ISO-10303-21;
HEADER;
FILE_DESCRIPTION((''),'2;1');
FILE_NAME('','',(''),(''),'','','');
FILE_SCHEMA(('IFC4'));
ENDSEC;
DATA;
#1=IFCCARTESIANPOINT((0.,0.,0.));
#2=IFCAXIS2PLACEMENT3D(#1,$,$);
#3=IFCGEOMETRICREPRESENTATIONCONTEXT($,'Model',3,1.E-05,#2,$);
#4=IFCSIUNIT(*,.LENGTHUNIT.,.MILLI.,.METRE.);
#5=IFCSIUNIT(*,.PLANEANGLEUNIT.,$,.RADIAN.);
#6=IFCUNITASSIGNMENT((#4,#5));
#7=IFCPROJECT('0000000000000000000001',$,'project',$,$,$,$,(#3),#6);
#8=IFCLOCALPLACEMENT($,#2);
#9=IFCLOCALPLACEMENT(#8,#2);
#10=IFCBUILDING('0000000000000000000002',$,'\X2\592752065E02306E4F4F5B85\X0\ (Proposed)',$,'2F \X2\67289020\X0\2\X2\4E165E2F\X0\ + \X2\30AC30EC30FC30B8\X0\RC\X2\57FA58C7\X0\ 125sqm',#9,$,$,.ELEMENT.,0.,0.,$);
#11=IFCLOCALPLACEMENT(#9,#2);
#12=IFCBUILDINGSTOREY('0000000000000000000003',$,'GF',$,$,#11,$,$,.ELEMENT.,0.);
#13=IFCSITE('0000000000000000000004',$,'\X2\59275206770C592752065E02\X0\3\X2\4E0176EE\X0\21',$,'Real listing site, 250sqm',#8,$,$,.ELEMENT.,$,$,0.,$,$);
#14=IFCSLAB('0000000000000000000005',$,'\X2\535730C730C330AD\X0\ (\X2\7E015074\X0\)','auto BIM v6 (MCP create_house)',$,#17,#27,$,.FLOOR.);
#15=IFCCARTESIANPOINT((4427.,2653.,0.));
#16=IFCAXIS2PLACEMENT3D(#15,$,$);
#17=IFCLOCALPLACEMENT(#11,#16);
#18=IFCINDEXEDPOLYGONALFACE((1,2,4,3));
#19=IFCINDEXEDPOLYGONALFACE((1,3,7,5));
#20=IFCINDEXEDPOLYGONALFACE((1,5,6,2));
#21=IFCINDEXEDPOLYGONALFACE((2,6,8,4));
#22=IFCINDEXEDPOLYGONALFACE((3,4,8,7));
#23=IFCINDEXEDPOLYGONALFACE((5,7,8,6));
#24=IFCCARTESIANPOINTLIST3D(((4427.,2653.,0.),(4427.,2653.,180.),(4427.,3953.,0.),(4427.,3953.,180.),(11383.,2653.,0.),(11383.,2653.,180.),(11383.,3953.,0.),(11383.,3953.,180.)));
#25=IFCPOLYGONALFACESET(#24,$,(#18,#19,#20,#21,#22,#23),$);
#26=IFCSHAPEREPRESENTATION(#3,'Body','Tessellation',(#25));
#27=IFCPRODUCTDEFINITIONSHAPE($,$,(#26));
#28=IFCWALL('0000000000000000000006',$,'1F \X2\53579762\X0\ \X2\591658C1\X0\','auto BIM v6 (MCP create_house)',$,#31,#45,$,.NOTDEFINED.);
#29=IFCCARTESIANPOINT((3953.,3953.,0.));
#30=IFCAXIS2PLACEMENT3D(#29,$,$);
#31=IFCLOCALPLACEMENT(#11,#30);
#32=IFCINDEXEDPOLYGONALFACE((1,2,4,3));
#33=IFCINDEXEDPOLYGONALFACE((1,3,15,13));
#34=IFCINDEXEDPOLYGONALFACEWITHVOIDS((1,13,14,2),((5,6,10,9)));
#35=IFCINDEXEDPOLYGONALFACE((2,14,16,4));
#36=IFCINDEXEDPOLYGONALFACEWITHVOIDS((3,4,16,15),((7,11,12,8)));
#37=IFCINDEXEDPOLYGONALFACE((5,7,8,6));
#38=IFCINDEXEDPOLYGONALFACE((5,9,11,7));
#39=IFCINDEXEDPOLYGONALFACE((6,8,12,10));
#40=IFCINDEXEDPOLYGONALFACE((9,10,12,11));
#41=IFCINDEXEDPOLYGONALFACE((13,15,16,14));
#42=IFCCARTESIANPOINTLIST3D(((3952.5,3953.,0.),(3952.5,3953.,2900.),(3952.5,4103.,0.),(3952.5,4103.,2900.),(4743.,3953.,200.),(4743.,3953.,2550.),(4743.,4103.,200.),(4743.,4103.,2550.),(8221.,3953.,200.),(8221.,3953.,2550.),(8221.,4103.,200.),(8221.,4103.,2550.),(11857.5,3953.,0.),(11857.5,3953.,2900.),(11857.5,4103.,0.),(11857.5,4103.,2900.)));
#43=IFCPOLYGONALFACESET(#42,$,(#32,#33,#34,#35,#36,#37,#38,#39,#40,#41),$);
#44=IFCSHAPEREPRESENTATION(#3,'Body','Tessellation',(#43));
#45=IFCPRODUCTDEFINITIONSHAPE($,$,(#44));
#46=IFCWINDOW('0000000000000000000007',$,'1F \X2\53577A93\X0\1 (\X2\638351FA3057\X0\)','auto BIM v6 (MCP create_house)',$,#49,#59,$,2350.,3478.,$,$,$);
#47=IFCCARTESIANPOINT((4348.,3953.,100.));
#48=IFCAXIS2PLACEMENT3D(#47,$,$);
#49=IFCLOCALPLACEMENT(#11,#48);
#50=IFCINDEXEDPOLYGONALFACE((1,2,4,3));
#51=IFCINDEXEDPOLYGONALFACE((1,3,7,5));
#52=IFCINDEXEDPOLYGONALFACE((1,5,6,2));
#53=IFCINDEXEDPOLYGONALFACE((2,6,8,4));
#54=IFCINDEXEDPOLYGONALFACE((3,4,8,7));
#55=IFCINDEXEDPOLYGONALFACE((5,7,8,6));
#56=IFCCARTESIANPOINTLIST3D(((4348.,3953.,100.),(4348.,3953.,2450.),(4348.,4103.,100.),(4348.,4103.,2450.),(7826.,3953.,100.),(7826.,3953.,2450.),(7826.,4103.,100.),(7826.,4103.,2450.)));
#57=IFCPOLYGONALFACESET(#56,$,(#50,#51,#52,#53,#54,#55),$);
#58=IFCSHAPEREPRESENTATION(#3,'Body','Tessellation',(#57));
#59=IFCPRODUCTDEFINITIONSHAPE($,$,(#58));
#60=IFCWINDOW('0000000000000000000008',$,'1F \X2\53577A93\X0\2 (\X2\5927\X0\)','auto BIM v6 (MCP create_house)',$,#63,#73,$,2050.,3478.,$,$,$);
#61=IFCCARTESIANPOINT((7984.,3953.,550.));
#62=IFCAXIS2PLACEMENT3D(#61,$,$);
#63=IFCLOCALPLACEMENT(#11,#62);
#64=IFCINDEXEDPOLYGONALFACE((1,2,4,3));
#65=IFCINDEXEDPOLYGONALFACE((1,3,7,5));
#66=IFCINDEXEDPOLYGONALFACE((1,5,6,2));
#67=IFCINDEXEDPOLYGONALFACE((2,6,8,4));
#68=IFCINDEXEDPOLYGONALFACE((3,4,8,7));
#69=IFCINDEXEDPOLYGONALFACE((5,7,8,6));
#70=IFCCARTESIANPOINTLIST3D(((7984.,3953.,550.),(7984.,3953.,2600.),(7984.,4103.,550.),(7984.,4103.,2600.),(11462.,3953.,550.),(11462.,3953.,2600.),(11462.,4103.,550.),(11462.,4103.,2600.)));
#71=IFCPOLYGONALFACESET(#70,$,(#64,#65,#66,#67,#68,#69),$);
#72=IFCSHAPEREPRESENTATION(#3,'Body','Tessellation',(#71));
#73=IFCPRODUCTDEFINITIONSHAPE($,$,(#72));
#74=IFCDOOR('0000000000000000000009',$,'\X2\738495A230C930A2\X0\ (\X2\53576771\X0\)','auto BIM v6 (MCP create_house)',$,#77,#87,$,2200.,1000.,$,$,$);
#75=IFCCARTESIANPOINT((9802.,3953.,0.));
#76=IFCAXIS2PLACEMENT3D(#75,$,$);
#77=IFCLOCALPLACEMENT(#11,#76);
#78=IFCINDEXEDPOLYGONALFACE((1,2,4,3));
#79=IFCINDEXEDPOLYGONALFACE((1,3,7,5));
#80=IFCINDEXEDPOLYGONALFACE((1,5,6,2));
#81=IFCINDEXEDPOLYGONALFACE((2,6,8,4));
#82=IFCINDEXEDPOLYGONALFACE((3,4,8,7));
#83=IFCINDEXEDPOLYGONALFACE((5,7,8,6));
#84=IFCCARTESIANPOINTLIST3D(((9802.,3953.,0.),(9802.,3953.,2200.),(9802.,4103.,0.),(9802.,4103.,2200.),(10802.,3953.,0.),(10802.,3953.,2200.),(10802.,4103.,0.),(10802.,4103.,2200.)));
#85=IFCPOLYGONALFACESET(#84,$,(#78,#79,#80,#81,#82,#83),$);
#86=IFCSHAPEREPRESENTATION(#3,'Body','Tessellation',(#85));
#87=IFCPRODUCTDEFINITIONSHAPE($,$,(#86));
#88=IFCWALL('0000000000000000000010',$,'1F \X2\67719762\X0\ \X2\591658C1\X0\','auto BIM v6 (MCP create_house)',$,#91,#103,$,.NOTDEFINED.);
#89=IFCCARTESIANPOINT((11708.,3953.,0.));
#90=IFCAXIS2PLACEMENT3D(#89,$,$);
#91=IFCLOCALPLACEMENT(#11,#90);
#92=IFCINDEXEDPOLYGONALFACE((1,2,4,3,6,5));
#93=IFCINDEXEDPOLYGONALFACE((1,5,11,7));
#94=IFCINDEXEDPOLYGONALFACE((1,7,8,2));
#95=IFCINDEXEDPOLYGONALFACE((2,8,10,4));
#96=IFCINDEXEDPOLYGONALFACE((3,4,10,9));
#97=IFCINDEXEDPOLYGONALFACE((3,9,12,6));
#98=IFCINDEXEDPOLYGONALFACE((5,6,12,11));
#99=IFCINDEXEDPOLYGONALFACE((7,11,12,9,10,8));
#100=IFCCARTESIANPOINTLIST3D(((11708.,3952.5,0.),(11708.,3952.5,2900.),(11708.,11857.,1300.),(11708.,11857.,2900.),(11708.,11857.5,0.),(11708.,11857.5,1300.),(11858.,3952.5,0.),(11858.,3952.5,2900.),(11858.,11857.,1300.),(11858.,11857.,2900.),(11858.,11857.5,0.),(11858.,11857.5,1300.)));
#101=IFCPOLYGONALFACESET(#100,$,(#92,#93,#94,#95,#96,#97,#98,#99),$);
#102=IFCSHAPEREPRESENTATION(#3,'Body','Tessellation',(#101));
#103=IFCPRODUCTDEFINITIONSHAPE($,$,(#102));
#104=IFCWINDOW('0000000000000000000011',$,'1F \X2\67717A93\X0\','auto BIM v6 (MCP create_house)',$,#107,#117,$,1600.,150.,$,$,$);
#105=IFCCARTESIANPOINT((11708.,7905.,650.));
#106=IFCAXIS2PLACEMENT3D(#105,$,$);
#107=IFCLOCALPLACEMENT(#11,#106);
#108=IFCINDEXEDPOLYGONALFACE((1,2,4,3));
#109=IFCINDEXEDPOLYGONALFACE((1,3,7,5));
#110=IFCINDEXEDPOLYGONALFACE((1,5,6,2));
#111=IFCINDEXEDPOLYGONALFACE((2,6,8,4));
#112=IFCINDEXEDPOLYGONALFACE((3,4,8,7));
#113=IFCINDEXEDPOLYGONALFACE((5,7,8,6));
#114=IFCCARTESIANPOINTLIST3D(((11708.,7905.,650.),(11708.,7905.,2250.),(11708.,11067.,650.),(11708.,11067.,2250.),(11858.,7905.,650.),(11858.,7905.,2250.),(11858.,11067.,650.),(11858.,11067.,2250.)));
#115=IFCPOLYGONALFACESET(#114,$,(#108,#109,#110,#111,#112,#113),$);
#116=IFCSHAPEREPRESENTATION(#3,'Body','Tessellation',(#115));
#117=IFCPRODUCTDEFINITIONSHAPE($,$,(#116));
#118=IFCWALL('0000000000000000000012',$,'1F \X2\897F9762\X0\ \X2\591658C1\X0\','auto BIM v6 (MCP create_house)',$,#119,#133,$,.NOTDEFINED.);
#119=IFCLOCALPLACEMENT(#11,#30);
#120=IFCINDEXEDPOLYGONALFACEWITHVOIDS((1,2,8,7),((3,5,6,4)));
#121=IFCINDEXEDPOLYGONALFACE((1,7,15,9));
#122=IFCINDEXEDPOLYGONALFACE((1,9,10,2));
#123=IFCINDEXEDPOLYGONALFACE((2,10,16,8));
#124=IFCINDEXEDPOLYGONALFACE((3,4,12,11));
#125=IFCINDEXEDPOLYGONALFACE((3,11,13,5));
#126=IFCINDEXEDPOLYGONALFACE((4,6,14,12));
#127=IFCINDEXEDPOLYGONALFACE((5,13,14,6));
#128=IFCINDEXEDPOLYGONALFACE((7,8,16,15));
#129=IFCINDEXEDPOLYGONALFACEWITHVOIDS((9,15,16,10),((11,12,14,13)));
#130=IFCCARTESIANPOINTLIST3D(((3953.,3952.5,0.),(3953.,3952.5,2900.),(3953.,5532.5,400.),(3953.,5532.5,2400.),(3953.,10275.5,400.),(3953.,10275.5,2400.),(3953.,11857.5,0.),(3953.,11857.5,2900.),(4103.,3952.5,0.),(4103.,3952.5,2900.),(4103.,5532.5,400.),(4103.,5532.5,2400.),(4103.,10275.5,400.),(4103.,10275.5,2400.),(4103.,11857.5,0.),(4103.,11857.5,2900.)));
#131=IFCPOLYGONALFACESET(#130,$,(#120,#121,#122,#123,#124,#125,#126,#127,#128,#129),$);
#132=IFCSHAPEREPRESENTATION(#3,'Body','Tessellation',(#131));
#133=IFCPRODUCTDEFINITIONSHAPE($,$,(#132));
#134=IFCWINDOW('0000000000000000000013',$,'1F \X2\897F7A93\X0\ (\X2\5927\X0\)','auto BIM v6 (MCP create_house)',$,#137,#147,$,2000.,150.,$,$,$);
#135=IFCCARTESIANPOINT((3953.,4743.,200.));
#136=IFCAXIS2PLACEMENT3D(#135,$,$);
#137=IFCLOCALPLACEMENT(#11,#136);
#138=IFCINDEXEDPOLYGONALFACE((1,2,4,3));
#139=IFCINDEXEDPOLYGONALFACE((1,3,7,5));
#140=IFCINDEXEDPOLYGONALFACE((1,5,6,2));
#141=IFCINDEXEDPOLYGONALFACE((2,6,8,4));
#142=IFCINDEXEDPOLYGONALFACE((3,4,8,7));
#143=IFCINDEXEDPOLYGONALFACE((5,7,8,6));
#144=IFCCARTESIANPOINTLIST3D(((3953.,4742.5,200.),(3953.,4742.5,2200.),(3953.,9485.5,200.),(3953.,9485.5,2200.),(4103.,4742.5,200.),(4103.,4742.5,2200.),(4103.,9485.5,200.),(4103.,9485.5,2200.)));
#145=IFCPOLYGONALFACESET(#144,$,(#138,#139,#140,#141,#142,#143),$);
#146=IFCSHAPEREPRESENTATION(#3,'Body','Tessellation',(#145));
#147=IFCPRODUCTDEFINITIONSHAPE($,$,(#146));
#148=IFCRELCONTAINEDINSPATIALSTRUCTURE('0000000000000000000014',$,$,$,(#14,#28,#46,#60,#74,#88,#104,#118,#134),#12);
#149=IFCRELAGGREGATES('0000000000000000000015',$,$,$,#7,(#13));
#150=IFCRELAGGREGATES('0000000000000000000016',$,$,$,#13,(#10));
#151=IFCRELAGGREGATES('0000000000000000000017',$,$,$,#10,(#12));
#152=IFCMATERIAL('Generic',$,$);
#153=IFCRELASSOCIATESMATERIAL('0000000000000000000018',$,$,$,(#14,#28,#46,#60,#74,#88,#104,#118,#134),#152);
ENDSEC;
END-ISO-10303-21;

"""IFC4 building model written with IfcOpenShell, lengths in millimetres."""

from ifc_helpers import new_model, si_unit, frame, frame_2d, origin, place, context, project, spatial, rectangle, extrude, material, element, fill, save


model = new_model("IFC4")

# Units and contexts
model_context = context("Model", 3, precision=1e-05, world=origin())
ifc_project = project(units=[si_unit("LENGTHUNIT", "METRE", prefix="MILLI"), si_unit("PLANEANGLEUNIT", "RADIAN")], contexts=[model_context])

# Site, building, storey
site_placement = place(None, origin())
site = spatial("IfcSite", under=ifc_project, at=site_placement, Name="大分県大分市3丁目21", ObjectType="Real listing site, 250sqm", CompositionType="ELEMENT", RefElevation=0.0)
building_placement = place(site_placement, origin())
building = spatial("IfcBuilding", under=site, at=building_placement, Name="大分市の住宅 (Proposed)", ObjectType="2F 木造2世帯 + ガレージRC基壇 125sqm", CompositionType="ELEMENT", ElevationOfRefHeight=0.0, ElevationOfTerrain=0.0)
storey_placement = place(building_placement, origin())
storey = spatial("IfcBuildingStorey", under=building, at=storey_placement, Name="GF", CompositionType="ELEMENT", Elevation=0.0)

# Slab
ifc_material = material(Name="Generic")
slab_1_placement = place(storey_placement, frame((4427.0, 2653.0, 0.0)))
element("IfcSlab", 1, at=slab_1_placement, inside=storey, material=ifc_material, Name="南デッキ (縁側)", Description="auto BIM v6 (MCP create_house)", PredefinedType="FLOOR", context=model_context, shape_type="SweptSolid", body=[
    extrude(rectangle(XDim=6956.0, YDim=1300.0, at=frame_2d((3478.0, 650.0))), frame((4427.0, 2653.0, 0.0)), (0.0, 0.0, 1.0), 180.0),
])

# Wall, openings, windows, door
wall_1_placement = place(storey_placement, frame((3953.0, 3953.0, 0.0)))
wall_1 = element("IfcWall", 2, at=wall_1_placement, inside=storey, material=ifc_material, Name="1F 南面 外壁", Description="auto BIM v6 (MCP create_house)", PredefinedType="NOTDEFINED", context=model_context, shape_type="SweptSolid", body=[
    extrude(rectangle(XDim=7905.0, YDim=150.0, at=frame_2d((3952.0, 75.0))), frame((3953.0, 3953.0, 0.0)), (0.0, 0.0, 1.0), 2900.0),
])
opening_1_placement = place(storey_placement, frame((4348.0, 3953.0, 100.0)))
opening_1 = element("IfcOpeningElement", 3, at=opening_1_placement, cuts=wall_1, PredefinedType="NOTDEFINED", context=model_context, shape_type="SweptSolid", body=[
    extrude(rectangle(XDim=3478.0, YDim=150.0, at=frame_2d((1739.0, 75.0))), frame((4348.0, 3953.0, 100.0)), (0.0, 0.0, 1.0), 2350.0),
])
opening_2_placement = place(storey_placement, frame((7984.0, 3953.0, 550.0)))
opening_2 = element("IfcOpeningElement", 4, at=opening_2_placement, cuts=wall_1, PredefinedType="NOTDEFINED", context=model_context, shape_type="SweptSolid", body=[
    extrude(rectangle(XDim=3478.0, YDim=150.0, at=frame_2d((1739.0, 75.0))), frame((7984.0, 3953.0, 550.0)), (0.0, 0.0, 1.0), 2050.0),
])
opening_3_placement = place(storey_placement, frame((9802.0, 3953.0, 0.0)))
opening_3 = element("IfcOpeningElement", 5, at=opening_3_placement, cuts=wall_1, PredefinedType="NOTDEFINED", context=model_context, shape_type="SweptSolid", body=[
    extrude(rectangle(XDim=1000.0, YDim=150.0, at=frame_2d((500.0, 75.0))), frame((9802.0, 3953.0, 0.0)), (0.0, 0.0, 1.0), 2200.0),
])
window_1_placement = place(storey_placement, frame((4348.0, 3953.0, 100.0)))
window_1 = element("IfcWindow", 6, at=window_1_placement, inside=storey, material=ifc_material, Name="1F 南窓1 (掃出し)", Description="auto BIM v6 (MCP create_house)", OverallHeight=2350.0, OverallWidth=3478.0, context=model_context, shape_type="SweptSolid", body=[
    extrude(rectangle(XDim=3478.0, YDim=150.0, at=frame_2d((1739.0, 75.0))), frame((4348.0, 3953.0, 100.0)), (0.0, 0.0, 1.0), 2350.0),
])
fill(opening_1, window_1)
window_2_placement = place(storey_placement, frame((7984.0, 3953.0, 550.0)))
window_2 = element("IfcWindow", 7, at=window_2_placement, inside=storey, material=ifc_material, Name="1F 南窓2 (大)", Description="auto BIM v6 (MCP create_house)", OverallHeight=2050.0, OverallWidth=3478.0, context=model_context, shape_type="SweptSolid", body=[
    extrude(rectangle(XDim=3478.0, YDim=150.0, at=frame_2d((1739.0, 75.0))), frame((7984.0, 3953.0, 550.0)), (0.0, 0.0, 1.0), 2050.0),
])
fill(opening_2, window_2)
door_placement = place(storey_placement, frame((9802.0, 3953.0, 0.0)))
door = element("IfcDoor", 8, at=door_placement, inside=storey, material=ifc_material, Name="玄関ドア (南東)", Description="auto BIM v6 (MCP create_house)", OverallHeight=2200.0, OverallWidth=1000.0, context=model_context, shape_type="SweptSolid", body=[
    extrude(rectangle(XDim=1000.0, YDim=150.0, at=frame_2d((500.0, 75.0))), frame((9802.0, 3953.0, 0.0)), (0.0, 0.0, 1.0), 2200.0),
])
fill(opening_3, door)

# Walls, openings, windows
wall_2_placement = place(storey_placement, frame((11708.0, 3953.0, 0.0)))
wall_2 = element("IfcWall", 9, at=wall_2_placement, inside=storey, material=ifc_material, Name="1F 東面 外壁", Description="auto BIM v6 (MCP create_house)", PredefinedType="NOTDEFINED", context=model_context, shape_type="SweptSolid", body=[
    extrude(rectangle(XDim=150.0, YDim=7905.0, at=frame_2d((75.0, 3952.0))), frame((11708.0, 3953.0, 0.0)), (0.0, 0.0, 1.0), 2900.0),
])
opening_4_placement = place(storey_placement, frame((11708.0, 7905.0, 650.0)))
opening_4 = element("IfcOpeningElement", 10, at=opening_4_placement, cuts=wall_2, PredefinedType="NOTDEFINED", context=model_context, shape_type="SweptSolid", body=[
    extrude(rectangle(XDim=150.0, YDim=3162.0, at=frame_2d((75.0, 1581.0))), frame((11708.0, 7905.0, 650.0)), (0.0, 0.0, 1.0), 1600.0),
])
window_3_placement = place(storey_placement, frame((11708.0, 7905.0, 650.0)))
window_3 = element("IfcWindow", 11, at=window_3_placement, inside=storey, material=ifc_material, Name="1F 東窓", Description="auto BIM v6 (MCP create_house)", OverallHeight=1600.0, OverallWidth=150.0, context=model_context, shape_type="SweptSolid", body=[
    extrude(rectangle(XDim=150.0, YDim=3162.0, at=frame_2d((75.0, 1581.0))), frame((11708.0, 7905.0, 650.0)), (0.0, 0.0, 1.0), 1600.0),
])
fill(opening_4, window_3)
wall_3_placement = place(storey_placement, frame((3953.0, 3953.0, 0.0)))
wall_3 = element("IfcWall", 12, at=wall_3_placement, inside=storey, material=ifc_material, Name="1F 西面 外壁", Description="auto BIM v6 (MCP create_house)", PredefinedType="NOTDEFINED", context=model_context, shape_type="SweptSolid", body=[
    extrude(rectangle(XDim=150.0, YDim=7905.0, at=frame_2d((75.0, 3952.0))), frame((3953.0, 3953.0, 0.0)), (0.0, 0.0, 1.0), 2900.0),
])
opening_5_placement = place(storey_placement, frame((3953.0, 4743.0, 200.0)))
opening_5 = element("IfcOpeningElement", 13, at=opening_5_placement, cuts=wall_3, PredefinedType="NOTDEFINED", context=model_context, shape_type="SweptSolid", body=[
    extrude(rectangle(XDim=150.0, YDim=4743.0, at=frame_2d((75.0, 2371.0))), frame((3953.0, 4743.0, 200.0)), (0.0, 0.0, 1.0), 2000.0),
])
window_4_placement = place(storey_placement, frame((3953.0, 4743.0, 200.0)))
window_4 = element("IfcWindow", 14, at=window_4_placement, inside=storey, material=ifc_material, Name="1F 西窓 (大)", Description="auto BIM v6 (MCP create_house)", OverallHeight=2000.0, OverallWidth=150.0, context=model_context, shape_type="SweptSolid", body=[
    extrude(rectangle(XDim=150.0, YDim=4743.0, at=frame_2d((75.0, 2371.0))), frame((3953.0, 4743.0, 200.0)), (0.0, 0.0, 1.0), 2000.0),
])
fill(opening_5, window_4)

save(model, "model.ifc")
